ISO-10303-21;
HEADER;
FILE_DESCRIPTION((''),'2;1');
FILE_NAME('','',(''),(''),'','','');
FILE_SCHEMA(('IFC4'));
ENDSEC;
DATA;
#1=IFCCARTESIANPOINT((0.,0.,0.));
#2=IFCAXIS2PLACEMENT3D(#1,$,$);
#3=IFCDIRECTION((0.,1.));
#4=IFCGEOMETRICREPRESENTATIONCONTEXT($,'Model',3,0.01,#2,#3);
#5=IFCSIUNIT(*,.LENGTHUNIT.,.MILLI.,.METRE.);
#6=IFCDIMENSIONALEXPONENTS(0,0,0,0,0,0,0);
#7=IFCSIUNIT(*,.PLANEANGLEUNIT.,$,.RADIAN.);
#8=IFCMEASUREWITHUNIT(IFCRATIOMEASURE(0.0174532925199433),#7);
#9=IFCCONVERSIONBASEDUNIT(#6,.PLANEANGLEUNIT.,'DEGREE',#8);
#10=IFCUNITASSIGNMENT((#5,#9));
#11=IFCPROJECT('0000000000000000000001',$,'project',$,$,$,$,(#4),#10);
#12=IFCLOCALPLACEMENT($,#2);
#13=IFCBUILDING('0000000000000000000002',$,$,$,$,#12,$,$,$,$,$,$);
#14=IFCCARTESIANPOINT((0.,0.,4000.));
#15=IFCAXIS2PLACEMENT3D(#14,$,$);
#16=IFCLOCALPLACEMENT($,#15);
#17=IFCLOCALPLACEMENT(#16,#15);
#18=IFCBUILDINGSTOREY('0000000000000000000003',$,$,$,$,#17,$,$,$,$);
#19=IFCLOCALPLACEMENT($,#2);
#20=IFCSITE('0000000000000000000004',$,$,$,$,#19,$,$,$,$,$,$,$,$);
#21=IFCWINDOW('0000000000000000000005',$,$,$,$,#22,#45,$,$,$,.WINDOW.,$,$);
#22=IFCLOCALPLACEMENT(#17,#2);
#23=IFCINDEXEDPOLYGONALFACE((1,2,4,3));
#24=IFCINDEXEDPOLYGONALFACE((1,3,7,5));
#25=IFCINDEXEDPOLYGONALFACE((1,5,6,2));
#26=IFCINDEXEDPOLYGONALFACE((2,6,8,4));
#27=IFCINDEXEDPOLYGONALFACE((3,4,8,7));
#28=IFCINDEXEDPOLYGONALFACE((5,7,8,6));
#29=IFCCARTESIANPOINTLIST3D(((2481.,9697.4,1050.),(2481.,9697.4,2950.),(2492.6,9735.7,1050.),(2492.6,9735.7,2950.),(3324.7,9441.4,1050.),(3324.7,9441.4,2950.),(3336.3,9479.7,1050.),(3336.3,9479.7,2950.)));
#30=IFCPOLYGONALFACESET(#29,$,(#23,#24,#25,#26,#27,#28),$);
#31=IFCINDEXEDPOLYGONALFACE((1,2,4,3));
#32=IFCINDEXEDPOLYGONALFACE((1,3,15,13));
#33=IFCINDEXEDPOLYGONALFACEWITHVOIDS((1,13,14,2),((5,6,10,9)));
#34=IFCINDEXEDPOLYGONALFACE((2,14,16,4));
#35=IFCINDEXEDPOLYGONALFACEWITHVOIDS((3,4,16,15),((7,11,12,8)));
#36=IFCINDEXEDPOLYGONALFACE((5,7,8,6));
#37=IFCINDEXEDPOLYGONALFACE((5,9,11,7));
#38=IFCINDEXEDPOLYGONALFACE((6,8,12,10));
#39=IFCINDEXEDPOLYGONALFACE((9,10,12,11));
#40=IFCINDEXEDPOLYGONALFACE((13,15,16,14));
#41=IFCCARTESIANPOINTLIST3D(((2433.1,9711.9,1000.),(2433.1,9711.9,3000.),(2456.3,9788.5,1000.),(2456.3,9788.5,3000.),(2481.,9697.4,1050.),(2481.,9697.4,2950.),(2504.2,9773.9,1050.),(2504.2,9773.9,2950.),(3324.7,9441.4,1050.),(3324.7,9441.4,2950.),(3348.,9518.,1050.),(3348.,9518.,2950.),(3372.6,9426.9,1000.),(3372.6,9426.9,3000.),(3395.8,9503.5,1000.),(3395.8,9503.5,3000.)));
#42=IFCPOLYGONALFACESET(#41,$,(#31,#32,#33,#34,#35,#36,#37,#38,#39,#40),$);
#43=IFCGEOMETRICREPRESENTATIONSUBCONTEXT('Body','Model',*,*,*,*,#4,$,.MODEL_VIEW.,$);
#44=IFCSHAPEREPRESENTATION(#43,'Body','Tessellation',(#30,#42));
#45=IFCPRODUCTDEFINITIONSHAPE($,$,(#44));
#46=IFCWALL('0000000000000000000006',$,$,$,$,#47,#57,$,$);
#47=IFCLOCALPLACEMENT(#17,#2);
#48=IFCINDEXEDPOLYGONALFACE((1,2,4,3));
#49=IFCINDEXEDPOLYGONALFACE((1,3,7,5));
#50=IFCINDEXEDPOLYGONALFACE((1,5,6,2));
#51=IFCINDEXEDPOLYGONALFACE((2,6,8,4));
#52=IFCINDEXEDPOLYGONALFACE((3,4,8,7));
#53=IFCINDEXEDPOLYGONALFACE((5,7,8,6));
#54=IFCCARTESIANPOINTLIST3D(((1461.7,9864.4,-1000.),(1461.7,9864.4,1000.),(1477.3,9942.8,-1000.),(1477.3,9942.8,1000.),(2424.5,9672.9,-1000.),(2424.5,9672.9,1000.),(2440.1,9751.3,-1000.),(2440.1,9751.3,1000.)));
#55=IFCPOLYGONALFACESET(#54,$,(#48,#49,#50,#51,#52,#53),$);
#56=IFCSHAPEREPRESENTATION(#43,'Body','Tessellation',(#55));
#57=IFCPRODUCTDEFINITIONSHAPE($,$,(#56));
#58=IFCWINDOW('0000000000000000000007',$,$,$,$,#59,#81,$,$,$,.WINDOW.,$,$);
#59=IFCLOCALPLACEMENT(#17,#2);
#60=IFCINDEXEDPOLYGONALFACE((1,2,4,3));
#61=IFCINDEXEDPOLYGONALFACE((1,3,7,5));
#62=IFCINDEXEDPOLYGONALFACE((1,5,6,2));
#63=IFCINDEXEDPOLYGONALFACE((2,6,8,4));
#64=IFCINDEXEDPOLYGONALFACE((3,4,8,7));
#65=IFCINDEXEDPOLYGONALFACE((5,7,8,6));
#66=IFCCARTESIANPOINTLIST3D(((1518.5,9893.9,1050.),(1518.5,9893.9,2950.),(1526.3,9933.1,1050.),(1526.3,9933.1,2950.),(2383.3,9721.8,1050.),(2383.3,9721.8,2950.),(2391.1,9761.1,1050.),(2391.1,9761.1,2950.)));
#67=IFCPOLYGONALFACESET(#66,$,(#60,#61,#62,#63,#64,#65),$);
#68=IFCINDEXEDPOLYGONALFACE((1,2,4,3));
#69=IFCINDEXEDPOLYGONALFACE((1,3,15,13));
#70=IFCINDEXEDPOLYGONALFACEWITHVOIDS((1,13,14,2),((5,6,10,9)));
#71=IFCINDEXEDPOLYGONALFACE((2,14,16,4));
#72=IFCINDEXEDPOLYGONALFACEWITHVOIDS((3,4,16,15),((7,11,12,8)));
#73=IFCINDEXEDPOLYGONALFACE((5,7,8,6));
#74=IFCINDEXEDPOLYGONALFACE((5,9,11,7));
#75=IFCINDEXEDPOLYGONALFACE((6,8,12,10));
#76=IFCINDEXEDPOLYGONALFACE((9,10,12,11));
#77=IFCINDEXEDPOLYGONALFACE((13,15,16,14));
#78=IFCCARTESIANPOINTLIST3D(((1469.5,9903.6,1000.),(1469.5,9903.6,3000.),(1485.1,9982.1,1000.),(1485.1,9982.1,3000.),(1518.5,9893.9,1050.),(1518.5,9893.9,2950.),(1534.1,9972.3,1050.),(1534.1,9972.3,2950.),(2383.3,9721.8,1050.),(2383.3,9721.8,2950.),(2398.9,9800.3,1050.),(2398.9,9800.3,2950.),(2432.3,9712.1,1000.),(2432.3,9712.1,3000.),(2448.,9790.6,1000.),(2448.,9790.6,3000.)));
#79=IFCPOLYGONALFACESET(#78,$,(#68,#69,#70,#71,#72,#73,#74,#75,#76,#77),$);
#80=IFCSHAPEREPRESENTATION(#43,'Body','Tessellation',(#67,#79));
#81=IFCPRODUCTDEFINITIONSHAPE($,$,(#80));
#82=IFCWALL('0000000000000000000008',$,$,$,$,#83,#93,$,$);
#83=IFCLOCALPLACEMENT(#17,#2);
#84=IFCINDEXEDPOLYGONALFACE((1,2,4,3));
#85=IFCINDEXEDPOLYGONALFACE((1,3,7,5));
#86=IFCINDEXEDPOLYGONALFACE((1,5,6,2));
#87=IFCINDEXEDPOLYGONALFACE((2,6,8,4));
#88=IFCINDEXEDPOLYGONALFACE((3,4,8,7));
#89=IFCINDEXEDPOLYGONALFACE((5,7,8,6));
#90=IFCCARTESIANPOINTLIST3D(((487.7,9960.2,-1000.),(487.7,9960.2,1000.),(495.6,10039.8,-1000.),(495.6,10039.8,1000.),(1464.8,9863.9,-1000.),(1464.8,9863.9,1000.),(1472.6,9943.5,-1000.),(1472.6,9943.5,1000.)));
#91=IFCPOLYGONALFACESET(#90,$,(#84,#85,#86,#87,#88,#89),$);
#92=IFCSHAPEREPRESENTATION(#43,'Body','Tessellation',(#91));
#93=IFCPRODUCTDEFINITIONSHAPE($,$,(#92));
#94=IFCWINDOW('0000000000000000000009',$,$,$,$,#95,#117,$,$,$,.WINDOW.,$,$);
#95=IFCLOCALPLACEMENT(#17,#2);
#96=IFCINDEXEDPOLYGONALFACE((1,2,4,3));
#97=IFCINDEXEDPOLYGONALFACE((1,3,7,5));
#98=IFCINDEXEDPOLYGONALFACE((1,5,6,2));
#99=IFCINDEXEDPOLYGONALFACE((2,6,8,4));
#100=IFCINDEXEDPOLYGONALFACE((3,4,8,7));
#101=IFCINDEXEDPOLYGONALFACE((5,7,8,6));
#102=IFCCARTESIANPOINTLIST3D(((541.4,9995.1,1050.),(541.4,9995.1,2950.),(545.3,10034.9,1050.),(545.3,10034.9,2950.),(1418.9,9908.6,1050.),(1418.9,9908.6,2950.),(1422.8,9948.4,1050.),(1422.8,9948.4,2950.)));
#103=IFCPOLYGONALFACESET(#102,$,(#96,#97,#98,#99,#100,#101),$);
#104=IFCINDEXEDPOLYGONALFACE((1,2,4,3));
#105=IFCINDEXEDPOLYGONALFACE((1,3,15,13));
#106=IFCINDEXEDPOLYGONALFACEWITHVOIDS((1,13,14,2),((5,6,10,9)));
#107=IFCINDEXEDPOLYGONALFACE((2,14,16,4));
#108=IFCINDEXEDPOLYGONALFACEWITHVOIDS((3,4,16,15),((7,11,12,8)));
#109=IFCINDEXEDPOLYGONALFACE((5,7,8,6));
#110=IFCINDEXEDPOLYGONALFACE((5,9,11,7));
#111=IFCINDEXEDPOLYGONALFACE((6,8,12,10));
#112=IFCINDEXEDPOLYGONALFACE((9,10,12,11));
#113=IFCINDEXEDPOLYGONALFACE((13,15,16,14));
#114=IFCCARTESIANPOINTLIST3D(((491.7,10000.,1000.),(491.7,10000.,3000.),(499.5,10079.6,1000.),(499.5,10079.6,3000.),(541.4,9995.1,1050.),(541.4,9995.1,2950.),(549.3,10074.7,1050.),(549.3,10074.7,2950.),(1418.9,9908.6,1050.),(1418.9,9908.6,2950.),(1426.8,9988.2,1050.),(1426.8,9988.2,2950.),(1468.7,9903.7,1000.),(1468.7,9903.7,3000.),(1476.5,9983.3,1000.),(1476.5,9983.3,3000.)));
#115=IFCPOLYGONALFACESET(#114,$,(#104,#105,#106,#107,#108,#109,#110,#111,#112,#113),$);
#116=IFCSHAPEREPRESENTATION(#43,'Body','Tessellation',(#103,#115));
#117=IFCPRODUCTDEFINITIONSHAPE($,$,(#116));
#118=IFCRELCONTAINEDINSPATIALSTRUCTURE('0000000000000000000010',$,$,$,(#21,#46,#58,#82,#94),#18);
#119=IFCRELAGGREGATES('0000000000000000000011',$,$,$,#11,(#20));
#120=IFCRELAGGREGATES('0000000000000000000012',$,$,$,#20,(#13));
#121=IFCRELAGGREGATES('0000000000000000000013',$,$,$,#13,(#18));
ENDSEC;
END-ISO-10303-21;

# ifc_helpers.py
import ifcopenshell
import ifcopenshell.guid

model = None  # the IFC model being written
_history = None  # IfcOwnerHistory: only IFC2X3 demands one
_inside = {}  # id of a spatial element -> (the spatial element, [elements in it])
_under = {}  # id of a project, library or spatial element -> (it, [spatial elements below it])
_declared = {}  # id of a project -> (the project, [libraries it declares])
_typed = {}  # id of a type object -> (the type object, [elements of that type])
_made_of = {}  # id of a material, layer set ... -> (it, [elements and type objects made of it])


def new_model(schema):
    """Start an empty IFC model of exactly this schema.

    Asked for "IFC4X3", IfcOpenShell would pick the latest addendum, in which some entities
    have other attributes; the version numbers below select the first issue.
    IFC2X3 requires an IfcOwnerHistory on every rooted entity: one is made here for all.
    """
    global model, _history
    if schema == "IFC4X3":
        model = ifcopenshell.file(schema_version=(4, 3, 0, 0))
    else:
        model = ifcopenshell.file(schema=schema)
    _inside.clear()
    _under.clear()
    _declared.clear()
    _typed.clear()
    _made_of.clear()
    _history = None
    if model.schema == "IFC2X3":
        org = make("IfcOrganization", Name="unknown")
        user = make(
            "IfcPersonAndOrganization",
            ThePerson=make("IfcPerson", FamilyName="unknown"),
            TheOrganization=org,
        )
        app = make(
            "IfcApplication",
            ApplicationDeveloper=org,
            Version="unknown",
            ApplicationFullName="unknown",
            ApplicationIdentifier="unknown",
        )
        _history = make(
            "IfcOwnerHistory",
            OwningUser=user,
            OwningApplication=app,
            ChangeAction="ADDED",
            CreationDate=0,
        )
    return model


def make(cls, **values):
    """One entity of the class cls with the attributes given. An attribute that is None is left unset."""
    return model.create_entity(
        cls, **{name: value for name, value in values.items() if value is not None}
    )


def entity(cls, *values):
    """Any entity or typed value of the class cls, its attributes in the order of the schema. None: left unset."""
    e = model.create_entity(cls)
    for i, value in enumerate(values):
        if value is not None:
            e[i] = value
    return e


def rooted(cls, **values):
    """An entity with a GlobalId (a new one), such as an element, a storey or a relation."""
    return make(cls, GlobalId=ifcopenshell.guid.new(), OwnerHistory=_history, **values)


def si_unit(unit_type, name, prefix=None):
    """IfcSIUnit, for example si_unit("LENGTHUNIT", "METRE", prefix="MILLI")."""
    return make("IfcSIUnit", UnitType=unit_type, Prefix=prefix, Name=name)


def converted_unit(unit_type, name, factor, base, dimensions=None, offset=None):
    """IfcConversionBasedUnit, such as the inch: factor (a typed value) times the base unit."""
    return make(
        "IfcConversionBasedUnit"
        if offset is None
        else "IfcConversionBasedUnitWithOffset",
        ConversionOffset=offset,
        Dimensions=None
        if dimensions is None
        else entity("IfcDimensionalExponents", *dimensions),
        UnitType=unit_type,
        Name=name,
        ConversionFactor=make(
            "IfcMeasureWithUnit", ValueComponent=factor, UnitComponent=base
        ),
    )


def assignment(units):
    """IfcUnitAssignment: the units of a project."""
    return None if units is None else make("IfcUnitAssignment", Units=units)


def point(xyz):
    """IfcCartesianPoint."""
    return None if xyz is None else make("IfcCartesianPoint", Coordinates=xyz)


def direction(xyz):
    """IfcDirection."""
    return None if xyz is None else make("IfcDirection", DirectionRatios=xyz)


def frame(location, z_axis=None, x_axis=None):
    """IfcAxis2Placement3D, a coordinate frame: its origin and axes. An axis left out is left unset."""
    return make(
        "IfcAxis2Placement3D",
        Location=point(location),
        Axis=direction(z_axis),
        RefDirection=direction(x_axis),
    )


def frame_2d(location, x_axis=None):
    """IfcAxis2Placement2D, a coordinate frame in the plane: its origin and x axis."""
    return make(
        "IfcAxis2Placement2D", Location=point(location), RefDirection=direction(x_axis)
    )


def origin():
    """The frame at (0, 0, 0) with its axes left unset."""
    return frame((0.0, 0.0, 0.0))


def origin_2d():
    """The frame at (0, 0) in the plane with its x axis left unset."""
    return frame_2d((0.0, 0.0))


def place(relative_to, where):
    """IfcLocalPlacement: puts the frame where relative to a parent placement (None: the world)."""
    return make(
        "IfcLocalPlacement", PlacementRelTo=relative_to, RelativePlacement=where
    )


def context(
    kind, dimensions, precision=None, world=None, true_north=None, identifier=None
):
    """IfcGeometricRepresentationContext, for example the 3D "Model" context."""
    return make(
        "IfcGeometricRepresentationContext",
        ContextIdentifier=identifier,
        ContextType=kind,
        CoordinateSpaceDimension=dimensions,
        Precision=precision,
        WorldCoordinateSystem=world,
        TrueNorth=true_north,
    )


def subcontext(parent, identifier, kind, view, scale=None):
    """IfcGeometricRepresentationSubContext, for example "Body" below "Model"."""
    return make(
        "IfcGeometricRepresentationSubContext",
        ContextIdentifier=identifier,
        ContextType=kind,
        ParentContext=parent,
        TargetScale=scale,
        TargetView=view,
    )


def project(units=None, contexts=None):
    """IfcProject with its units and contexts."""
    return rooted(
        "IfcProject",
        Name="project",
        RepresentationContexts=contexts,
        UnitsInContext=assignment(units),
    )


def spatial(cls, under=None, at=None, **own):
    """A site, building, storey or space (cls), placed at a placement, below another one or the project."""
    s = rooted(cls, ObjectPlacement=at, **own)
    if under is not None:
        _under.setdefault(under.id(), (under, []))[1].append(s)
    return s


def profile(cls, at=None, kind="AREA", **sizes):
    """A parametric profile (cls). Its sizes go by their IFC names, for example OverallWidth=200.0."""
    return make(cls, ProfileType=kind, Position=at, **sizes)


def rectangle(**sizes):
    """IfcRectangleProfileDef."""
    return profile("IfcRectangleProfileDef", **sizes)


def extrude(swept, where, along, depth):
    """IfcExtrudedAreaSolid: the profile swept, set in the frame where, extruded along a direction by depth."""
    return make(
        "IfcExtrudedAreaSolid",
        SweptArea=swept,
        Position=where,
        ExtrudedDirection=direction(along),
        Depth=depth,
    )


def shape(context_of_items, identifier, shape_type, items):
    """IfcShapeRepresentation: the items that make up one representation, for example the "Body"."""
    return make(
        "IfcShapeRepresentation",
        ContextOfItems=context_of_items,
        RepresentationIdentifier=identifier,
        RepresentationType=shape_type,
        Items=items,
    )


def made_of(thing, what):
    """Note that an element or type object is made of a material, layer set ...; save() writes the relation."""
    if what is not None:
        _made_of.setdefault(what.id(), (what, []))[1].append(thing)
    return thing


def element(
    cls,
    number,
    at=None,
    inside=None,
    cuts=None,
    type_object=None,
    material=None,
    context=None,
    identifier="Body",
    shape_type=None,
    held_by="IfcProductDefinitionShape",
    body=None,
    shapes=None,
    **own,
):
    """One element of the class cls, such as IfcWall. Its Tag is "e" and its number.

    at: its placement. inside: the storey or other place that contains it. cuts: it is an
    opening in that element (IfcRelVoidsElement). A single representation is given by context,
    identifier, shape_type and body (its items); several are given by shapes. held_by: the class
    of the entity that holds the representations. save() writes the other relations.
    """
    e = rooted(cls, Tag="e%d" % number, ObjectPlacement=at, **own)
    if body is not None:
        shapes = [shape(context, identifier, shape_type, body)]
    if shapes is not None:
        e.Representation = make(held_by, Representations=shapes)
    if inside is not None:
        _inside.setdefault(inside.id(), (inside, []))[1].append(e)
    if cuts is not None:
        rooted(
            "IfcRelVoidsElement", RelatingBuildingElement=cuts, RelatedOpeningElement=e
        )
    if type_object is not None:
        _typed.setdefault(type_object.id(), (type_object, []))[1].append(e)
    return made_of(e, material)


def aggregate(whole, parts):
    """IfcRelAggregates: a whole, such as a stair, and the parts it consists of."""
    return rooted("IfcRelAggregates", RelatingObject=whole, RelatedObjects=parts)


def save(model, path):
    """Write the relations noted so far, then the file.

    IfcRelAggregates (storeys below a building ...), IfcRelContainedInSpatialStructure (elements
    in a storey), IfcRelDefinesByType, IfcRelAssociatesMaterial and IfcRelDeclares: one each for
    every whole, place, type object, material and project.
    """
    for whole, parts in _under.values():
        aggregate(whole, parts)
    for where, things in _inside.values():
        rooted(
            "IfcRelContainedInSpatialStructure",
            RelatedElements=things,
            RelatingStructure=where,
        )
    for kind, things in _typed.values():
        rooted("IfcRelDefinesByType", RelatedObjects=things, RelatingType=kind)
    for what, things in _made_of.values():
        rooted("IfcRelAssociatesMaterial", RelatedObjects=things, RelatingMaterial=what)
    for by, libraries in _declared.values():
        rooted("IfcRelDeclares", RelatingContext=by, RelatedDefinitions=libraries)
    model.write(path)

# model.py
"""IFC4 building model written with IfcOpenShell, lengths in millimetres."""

from ifc_helpers import new_model, entity, si_unit, converted_unit, direction, frame, origin, origin_2d, place, context, subcontext, project, spatial, rectangle, extrude, element, save


model = new_model("IFC4")

# Units and contexts
model_context = context("Model", 3, precision=0.01, world=origin(), true_north=direction((0.0, 1.0)))
body_context = subcontext(model_context, "Body", "Model", "MODEL_VIEW")
ifc_project = project(units=[si_unit("LENGTHUNIT", "METRE", prefix="MILLI"), converted_unit("PLANEANGLEUNIT", "DEGREE", entity("IfcRatioMeasure", 0.0174532925199433), si_unit("PLANEANGLEUNIT", "RADIAN"), dimensions=[0, 0, 0, 0, 0, 0, 0])], contexts=[model_context])

# Site, building, storey
site_placement = place(None, origin())
site = spatial("IfcSite", under=ifc_project, at=site_placement)
building_placement = place(None, origin())
building = spatial("IfcBuilding", under=site, at=building_placement)
placement = place(None, frame((0.0, 0.0, 4000.0)))
storey_placement = place(placement, frame((0.0, 0.0, 4000.0)))
storey = spatial("IfcBuildingStorey", under=building, at=storey_placement)

# Shared definitions
cartesian_point_1 = entity("IfcCartesianPoint", [-440.9, -950.0])
shared_polyline = entity("IfcPolyline", [cartesian_point_1, entity("IfcCartesianPoint", [-440.9, 950.0]), entity("IfcCartesianPoint", [-440.9, 950.0]), entity("IfcCartesianPoint", [440.9, 950.0]), entity("IfcCartesianPoint", [440.9, 950.0]), entity("IfcCartesianPoint", [440.9, -950.0]), entity("IfcCartesianPoint", [440.9, -950.0]), entity("IfcCartesianPoint", [-440.9, -950.0]), cartesian_point_1])

# Window
window_1_placement = place(storey_placement, frame((2902.8, 9569.4, 2000.0), z_axis=(0.0, 0.0, 1.0), x_axis=(-9569.403482, 2902.846361, 0.0)))
cartesian_point_2 = entity("IfcCartesianPoint", [-490.9, -1000.0])
element("IfcWindow", 1, at=window_1_placement, inside=storey, PredefinedType="WINDOW", context=body_context, shape_type="SweptSolid", body=[
    entity("IfcExtrudedAreaSolid", entity("IfcArbitraryClosedProfileDef", "AREA", None, shared_polyline), entity("IfcAxis2Placement3D", entity("IfcCartesianPoint", [0.0, 0.0, 0.0]), entity("IfcDirection", [0.0, -1.0, 0.0]), entity("IfcDirection", [1.0, 0.0, 0.0])), entity("IfcDirection", [0.0, 0.0, 1.0]), 40.0),
    entity("IfcExtrudedAreaSolid", entity("IfcArbitraryProfileDefWithVoids", "AREA", None, entity("IfcPolyline", [cartesian_point_2, entity("IfcCartesianPoint", [-490.9, 1000.0]), entity("IfcCartesianPoint", [-490.9, 1000.0]), entity("IfcCartesianPoint", [490.9, 1000.0]), entity("IfcCartesianPoint", [490.9, 1000.0]), entity("IfcCartesianPoint", [490.9, -1000.0]), entity("IfcCartesianPoint", [490.9, -1000.0]), entity("IfcCartesianPoint", [-490.9, -1000.0]), cartesian_point_2]), [shared_polyline]), entity("IfcAxis2Placement3D", entity("IfcCartesianPoint", [0.0, 0.0, 0.0]), entity("IfcDirection", [0.0, -1.0, 0.0]), entity("IfcDirection", [1.0, 0.0, 0.0])), entity("IfcDirection", [0.0, 0.0, 1.0]), 80.0),
])

# Wall
wall_1_placement = place(storey_placement, frame((1950.9, 9807.9, -1000.0), z_axis=(0.0, 0.0, 1.0), x_axis=(-9807.852733, 1950.903576, 0.0)))
element("IfcWall", 2, at=wall_1_placement, inside=storey, context=body_context, shape_type="SweptSolid", body=[
    extrude(rectangle(XDim=981.7, YDim=80.0, at=origin_2d()), origin(), (0.0, 0.0, 1.0), 2000.0),
])

# Window
window_2_placement = place(storey_placement, frame((1950.9, 9807.9, 2000.0), z_axis=(0.0, 0.0, 1.0), x_axis=(-9807.852733, 1950.903576, 0.0)))
cartesian_point_3 = entity("IfcCartesianPoint", [-490.9, -1000.0])
element("IfcWindow", 3, at=window_2_placement, inside=storey, PredefinedType="WINDOW", context=body_context, shape_type="SweptSolid", body=[
    entity("IfcExtrudedAreaSolid", entity("IfcArbitraryClosedProfileDef", "AREA", None, shared_polyline), entity("IfcAxis2Placement3D", entity("IfcCartesianPoint", [0.0, 0.0, 0.0]), entity("IfcDirection", [0.0, -1.0, 0.0]), entity("IfcDirection", [1.0, 0.0, 0.0])), entity("IfcDirection", [0.0, 0.0, 1.0]), 40.0),
    entity("IfcExtrudedAreaSolid", entity("IfcArbitraryProfileDefWithVoids", "AREA", None, entity("IfcPolyline", [cartesian_point_3, entity("IfcCartesianPoint", [-490.9, 1000.0]), entity("IfcCartesianPoint", [-490.9, 1000.0]), entity("IfcCartesianPoint", [490.9, 1000.0]), entity("IfcCartesianPoint", [490.9, 1000.0]), entity("IfcCartesianPoint", [490.9, -1000.0]), entity("IfcCartesianPoint", [490.9, -1000.0]), entity("IfcCartesianPoint", [-490.9, -1000.0]), cartesian_point_3]), [shared_polyline]), entity("IfcAxis2Placement3D", entity("IfcCartesianPoint", [0.0, 0.0, 0.0]), entity("IfcDirection", [0.0, -1.0, 0.0]), entity("IfcDirection", [1.0, 0.0, 0.0])), entity("IfcDirection", [0.0, 0.0, 1.0]), 80.0),
])

# Wall
wall_2_placement = place(storey_placement, frame((980.2, 9951.8, -1000.0), z_axis=(0.0, 0.0, 1.0), x_axis=(-9951.84727, 980.171366, 0.0)))
element("IfcWall", 4, at=wall_2_placement, inside=storey, context=body_context, shape_type="SweptSolid", body=[
    extrude(rectangle(XDim=981.7, YDim=80.0, at=origin_2d()), origin(), (0.0, 0.0, 1.0), 2000.0),
])

# Window
window_3_placement = place(storey_placement, frame((980.2, 9951.8, 2000.0), z_axis=(0.0, 0.0, 1.0), x_axis=(-9951.84727, 980.171366, 0.0)))
cartesian_point_4 = entity("IfcCartesianPoint", [-490.9, -1000.0])
element("IfcWindow", 5, at=window_3_placement, inside=storey, PredefinedType="WINDOW", context=body_context, shape_type="SweptSolid", body=[
    entity("IfcExtrudedAreaSolid", entity("IfcArbitraryClosedProfileDef", "AREA", None, shared_polyline), entity("IfcAxis2Placement3D", entity("IfcCartesianPoint", [0.0, 0.0, 0.0]), entity("IfcDirection", [0.0, -1.0, 0.0]), entity("IfcDirection", [1.0, 0.0, 0.0])), entity("IfcDirection", [0.0, 0.0, 1.0]), 40.0),
    entity("IfcExtrudedAreaSolid", entity("IfcArbitraryProfileDefWithVoids", "AREA", None, entity("IfcPolyline", [cartesian_point_4, entity("IfcCartesianPoint", [-490.9, 1000.0]), entity("IfcCartesianPoint", [-490.9, 1000.0]), entity("IfcCartesianPoint", [490.9, 1000.0]), entity("IfcCartesianPoint", [490.9, 1000.0]), entity("IfcCartesianPoint", [490.9, -1000.0]), entity("IfcCartesianPoint", [490.9, -1000.0]), entity("IfcCartesianPoint", [-490.9, -1000.0]), cartesian_point_4]), [shared_polyline]), entity("IfcAxis2Placement3D", entity("IfcCartesianPoint", [0.0, 0.0, 0.0]), entity("IfcDirection", [0.0, -1.0, 0.0]), entity("IfcDirection", [1.0, 0.0, 0.0])), entity("IfcDirection", [0.0, 0.0, 1.0]), 80.0),
])

save(model, "model.ifc")
